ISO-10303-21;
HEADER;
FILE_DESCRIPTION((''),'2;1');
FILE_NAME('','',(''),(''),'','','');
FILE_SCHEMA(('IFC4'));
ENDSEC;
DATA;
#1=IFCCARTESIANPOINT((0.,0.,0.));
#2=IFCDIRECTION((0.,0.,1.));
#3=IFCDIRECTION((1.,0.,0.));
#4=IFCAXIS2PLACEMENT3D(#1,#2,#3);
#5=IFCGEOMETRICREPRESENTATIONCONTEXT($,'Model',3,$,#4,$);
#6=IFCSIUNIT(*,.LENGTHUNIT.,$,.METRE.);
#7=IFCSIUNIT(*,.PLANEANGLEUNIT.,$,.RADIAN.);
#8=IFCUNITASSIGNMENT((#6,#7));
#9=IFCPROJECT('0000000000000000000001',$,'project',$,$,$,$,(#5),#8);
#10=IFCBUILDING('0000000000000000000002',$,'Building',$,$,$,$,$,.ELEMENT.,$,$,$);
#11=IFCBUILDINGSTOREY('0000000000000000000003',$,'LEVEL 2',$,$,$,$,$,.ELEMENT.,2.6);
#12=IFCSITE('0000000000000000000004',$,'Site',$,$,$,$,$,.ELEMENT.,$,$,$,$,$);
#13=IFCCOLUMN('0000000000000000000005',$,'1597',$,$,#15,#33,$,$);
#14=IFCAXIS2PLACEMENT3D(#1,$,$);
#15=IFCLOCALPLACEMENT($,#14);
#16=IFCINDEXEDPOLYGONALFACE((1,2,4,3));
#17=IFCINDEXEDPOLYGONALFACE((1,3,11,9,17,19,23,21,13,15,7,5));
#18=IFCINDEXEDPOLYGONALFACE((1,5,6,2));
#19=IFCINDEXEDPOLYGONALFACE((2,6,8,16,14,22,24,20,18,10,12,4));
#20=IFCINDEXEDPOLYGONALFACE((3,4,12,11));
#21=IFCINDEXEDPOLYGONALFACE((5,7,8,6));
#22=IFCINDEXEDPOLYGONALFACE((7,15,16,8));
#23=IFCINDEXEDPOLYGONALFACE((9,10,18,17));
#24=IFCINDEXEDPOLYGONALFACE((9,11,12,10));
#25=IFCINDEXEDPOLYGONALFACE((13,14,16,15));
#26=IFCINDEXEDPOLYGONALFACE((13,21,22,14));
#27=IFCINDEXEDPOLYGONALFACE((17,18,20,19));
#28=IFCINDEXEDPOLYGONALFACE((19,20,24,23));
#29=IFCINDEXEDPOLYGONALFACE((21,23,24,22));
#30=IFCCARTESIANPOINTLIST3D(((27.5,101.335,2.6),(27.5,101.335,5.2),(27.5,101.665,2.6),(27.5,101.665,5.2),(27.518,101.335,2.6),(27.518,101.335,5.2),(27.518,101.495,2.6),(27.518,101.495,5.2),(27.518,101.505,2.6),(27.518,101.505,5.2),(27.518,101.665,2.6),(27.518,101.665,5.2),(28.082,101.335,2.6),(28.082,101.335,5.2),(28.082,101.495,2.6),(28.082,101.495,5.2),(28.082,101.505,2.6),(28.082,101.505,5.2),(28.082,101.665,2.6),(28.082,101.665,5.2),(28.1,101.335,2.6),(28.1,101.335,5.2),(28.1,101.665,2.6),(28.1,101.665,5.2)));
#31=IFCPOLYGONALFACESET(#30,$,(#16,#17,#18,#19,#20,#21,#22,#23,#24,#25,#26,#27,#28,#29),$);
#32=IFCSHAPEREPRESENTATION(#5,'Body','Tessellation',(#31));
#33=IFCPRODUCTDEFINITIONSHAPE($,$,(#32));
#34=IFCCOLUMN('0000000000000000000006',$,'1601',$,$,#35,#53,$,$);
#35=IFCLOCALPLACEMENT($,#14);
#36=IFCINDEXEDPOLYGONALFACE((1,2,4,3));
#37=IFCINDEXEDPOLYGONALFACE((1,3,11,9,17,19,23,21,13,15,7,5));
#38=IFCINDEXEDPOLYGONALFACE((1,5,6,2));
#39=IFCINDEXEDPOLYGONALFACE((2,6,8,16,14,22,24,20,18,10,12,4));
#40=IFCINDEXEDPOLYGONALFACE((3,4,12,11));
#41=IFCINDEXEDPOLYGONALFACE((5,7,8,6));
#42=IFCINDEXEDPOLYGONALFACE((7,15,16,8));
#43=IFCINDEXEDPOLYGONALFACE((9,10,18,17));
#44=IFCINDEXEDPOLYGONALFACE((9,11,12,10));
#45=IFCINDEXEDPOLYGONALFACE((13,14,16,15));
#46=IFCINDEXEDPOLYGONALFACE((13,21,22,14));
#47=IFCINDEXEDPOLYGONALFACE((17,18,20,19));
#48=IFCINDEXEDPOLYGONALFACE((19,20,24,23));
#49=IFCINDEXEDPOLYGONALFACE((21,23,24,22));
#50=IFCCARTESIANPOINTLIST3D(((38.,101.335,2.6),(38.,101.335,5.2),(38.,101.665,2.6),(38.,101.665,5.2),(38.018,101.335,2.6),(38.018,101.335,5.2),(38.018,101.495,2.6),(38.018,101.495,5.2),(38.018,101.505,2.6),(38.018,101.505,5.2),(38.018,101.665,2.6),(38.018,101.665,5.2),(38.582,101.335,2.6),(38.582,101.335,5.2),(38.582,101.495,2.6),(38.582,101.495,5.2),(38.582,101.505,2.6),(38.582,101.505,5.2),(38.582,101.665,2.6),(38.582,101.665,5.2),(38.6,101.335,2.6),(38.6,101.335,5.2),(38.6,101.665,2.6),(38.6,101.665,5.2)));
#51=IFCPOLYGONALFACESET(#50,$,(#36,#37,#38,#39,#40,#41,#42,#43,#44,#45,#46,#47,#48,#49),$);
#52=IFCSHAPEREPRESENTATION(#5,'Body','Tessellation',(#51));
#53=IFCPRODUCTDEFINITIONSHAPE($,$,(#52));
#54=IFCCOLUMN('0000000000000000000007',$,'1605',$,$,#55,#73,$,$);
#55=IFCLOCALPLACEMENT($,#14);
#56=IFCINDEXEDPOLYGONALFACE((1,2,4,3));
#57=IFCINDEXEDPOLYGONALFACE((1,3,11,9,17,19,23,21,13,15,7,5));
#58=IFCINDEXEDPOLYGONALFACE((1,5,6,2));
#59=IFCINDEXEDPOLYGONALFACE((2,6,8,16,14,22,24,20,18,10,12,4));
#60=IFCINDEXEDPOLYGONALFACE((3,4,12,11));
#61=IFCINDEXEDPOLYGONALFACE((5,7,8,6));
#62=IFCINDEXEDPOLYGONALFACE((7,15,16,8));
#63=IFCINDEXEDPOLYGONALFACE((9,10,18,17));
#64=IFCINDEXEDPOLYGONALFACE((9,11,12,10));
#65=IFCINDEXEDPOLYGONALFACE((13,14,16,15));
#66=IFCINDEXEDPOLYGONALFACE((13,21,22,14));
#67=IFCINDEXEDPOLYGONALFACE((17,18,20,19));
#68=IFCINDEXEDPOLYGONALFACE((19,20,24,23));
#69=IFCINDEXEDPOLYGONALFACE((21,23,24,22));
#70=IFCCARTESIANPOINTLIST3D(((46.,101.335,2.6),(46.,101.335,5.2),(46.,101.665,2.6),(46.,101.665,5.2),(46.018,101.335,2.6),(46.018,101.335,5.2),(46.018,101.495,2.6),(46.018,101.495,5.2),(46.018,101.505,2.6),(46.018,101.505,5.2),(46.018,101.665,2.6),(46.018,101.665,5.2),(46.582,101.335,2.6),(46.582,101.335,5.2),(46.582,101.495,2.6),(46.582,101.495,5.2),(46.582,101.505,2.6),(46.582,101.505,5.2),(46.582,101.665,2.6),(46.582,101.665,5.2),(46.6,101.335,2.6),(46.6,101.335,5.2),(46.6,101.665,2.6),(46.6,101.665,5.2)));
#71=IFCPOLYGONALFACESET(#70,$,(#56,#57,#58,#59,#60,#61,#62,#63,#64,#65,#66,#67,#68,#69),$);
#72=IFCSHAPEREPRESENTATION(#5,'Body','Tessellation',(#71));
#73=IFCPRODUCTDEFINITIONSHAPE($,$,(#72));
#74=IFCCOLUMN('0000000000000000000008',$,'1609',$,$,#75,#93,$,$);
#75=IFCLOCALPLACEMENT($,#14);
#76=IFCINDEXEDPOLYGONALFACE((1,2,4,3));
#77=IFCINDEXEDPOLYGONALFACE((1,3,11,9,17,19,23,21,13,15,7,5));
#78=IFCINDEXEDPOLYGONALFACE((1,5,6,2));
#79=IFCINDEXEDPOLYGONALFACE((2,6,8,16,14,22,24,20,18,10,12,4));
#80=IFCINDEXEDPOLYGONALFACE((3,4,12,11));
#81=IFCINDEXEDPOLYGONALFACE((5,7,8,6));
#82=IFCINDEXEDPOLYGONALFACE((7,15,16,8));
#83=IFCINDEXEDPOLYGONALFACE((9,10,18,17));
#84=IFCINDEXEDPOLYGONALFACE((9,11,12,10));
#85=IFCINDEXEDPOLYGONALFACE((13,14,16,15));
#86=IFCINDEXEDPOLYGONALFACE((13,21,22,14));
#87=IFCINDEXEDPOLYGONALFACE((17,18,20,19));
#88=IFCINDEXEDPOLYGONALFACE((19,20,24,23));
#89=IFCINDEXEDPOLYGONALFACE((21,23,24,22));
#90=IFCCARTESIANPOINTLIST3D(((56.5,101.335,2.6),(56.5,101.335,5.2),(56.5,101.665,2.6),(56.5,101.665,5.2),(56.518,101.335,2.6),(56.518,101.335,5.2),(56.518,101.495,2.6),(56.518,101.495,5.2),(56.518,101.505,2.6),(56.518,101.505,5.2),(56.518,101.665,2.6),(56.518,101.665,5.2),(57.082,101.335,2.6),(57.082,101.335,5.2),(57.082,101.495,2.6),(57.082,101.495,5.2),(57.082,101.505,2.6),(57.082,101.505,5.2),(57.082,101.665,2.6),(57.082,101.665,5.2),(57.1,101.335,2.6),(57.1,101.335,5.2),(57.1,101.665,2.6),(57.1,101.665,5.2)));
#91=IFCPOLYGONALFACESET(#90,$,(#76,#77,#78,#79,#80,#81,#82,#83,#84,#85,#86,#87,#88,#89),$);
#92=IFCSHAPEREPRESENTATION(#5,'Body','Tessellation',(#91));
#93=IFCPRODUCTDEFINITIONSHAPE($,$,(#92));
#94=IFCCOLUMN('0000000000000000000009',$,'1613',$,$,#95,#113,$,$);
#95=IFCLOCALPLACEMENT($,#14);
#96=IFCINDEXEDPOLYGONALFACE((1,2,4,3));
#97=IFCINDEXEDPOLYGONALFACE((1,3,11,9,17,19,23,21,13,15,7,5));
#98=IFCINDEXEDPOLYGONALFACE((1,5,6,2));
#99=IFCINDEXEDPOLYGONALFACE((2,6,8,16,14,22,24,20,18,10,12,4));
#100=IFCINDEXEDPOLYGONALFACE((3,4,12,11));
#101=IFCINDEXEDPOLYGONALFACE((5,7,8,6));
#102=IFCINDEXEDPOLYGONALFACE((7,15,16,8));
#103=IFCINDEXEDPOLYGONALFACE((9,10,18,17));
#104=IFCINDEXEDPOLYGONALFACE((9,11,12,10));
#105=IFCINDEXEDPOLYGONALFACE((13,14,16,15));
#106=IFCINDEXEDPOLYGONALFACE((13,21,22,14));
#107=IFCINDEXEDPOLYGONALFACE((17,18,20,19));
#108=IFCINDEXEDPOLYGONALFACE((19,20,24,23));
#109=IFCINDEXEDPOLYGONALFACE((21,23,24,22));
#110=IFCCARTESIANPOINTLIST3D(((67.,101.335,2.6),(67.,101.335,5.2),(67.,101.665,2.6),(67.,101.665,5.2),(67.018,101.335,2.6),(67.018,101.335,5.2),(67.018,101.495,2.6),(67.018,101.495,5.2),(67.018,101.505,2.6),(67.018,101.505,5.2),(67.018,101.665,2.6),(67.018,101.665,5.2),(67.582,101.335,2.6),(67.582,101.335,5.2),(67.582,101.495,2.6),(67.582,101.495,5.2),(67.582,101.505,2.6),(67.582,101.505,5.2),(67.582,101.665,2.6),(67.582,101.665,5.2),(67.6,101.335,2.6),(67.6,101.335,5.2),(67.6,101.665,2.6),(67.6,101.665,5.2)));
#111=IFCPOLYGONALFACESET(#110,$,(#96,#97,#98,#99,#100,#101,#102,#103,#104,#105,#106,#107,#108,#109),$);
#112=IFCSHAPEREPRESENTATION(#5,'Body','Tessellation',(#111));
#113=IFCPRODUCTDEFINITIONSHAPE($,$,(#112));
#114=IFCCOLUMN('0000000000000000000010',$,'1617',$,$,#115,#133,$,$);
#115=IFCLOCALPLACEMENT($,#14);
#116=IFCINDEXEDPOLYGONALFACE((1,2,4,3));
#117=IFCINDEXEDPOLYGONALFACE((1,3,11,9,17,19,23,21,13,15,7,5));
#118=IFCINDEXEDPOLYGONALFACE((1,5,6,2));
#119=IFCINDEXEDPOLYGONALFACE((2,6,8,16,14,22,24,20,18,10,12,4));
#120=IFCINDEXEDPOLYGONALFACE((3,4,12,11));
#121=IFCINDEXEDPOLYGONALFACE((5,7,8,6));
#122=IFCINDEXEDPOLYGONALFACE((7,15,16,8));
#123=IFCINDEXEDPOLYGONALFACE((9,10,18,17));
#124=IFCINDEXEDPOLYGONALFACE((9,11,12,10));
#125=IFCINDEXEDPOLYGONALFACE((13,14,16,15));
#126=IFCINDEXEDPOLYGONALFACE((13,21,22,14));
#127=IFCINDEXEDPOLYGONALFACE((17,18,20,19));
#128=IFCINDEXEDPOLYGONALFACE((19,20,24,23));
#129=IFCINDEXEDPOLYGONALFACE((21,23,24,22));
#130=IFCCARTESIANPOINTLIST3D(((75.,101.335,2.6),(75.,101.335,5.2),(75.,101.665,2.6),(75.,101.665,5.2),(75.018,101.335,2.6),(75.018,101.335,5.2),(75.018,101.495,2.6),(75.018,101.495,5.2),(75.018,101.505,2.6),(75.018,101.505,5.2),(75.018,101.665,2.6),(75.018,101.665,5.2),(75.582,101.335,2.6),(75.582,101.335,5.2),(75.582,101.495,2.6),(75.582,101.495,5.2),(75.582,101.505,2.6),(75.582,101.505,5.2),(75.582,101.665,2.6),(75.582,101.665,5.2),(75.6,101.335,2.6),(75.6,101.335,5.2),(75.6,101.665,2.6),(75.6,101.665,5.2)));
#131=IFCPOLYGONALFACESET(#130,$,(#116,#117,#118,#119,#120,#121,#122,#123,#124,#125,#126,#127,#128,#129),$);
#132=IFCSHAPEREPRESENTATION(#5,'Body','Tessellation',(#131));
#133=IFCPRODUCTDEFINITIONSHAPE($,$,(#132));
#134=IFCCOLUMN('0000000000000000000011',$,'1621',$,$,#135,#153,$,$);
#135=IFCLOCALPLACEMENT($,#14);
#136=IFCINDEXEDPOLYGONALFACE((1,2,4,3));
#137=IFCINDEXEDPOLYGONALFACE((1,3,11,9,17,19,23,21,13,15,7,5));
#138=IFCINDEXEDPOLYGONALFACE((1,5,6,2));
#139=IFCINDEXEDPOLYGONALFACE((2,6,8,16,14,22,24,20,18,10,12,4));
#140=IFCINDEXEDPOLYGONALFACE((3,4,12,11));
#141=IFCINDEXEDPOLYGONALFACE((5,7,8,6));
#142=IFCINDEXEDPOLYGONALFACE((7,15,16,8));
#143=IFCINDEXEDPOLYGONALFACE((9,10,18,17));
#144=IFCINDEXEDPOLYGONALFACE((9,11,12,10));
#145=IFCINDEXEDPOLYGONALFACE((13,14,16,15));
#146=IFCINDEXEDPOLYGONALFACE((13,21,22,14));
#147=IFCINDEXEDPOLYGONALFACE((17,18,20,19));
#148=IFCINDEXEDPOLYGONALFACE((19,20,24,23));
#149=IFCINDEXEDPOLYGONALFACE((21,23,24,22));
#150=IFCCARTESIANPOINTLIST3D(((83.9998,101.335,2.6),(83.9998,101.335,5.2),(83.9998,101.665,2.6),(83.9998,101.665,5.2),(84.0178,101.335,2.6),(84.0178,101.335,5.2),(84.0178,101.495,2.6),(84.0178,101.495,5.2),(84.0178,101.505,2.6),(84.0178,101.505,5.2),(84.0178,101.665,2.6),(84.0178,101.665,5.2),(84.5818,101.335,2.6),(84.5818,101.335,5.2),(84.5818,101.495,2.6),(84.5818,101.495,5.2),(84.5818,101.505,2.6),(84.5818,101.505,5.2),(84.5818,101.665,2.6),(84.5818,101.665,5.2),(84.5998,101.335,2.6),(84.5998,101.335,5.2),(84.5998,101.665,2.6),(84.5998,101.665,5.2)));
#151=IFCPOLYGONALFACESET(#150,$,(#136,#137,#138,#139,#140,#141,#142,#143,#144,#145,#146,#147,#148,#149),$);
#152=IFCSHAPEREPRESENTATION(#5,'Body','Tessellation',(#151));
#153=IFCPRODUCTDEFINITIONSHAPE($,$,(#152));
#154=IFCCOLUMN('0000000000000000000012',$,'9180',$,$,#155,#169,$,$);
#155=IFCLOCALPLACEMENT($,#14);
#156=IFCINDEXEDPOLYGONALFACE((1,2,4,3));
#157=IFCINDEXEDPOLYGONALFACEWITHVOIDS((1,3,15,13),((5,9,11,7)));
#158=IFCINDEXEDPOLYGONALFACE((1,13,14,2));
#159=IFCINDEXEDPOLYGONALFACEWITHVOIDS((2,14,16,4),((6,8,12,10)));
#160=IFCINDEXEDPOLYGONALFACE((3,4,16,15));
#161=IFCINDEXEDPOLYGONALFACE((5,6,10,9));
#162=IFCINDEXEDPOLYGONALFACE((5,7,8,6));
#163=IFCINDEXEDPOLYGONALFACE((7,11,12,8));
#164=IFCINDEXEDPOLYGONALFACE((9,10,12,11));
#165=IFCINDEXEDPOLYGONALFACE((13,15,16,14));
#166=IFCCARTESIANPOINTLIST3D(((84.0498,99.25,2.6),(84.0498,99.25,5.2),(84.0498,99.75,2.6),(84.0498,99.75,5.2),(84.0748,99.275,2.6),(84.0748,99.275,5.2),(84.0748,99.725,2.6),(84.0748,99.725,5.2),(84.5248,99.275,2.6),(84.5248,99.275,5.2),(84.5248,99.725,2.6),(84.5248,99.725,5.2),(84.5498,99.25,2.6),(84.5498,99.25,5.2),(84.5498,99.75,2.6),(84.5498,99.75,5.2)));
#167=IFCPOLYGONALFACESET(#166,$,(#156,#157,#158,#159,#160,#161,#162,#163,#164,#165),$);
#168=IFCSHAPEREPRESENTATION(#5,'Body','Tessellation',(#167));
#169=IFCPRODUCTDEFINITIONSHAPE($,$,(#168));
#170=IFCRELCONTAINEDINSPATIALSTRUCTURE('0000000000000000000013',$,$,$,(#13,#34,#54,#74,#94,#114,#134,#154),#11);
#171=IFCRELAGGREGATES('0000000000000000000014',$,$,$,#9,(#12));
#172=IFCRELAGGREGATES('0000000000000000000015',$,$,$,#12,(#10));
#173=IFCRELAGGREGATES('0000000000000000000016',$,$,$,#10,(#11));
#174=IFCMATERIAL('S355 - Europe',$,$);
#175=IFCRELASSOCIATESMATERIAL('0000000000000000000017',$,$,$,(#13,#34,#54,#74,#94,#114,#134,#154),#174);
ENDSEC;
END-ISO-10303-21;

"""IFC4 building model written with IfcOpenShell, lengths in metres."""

from ifc_helpers import new_model, si_unit, frame, origin_with_axes, origin_2d_with_axis, place, context, project, spatial, hollow_rectangle, i_section, extrude, material, material_profile, profile_set, profile_usage, element, save


model = new_model("IFC4")

# Units and contexts
model_context = context("Model", 3, world=origin_with_axes())
ifc_project = project(units=[si_unit("LENGTHUNIT", "METRE"), si_unit("PLANEANGLEUNIT", "RADIAN")], contexts=[model_context])

# Site, building, storey
site = spatial("IfcSite", under=ifc_project, Name="Site", CompositionType="ELEMENT")
building = spatial("IfcBuilding", under=site, Name="Building", CompositionType="ELEMENT")
storey = spatial("IfcBuildingStorey", under=building, Name="LEVEL 2", CompositionType="ELEMENT", Elevation=2.6)

# Columns
ifc_material = material(Name="S355 - Europe")
ifc_material_profile_1 = material_profile(ifc_material, i_section(OverallWidth=0.33, OverallDepth=0.6, WebThickness=0.01, FlangeThickness=0.018, at=origin_2d_with_axis()))
ifc_profile_set_1 = profile_set([ifc_material_profile_1])
ifc_profile_usage_1 = profile_usage(ifc_profile_set_1, cardinal=10)
column_1_placement = place(None, frame((27.8, 101.5, 2.6), z_axis=(0.0, 0.0, 1.0), x_axis=(0.0, -1.0, 0.0)))
element("IfcColumn", 1, at=column_1_placement, inside=storey, material=ifc_profile_usage_1, Name="1597", context=model_context, shape_type="SweptSolid", body=[
    extrude(i_section(OverallWidth=0.33, OverallDepth=0.6, WebThickness=0.01, FlangeThickness=0.018, at=origin_2d_with_axis()), origin_with_axes(), (0.0, 0.0, 1.0), 2.6),
])
ifc_material_profile_2 = material_profile(ifc_material, i_section(OverallWidth=0.33, OverallDepth=0.6, WebThickness=0.01, FlangeThickness=0.018, at=origin_2d_with_axis()))
ifc_profile_set_2 = profile_set([ifc_material_profile_2])
ifc_profile_usage_2 = profile_usage(ifc_profile_set_2, cardinal=10)
column_2_placement = place(None, frame((38.3, 101.5, 2.6), z_axis=(0.0, 0.0, 1.0), x_axis=(0.0, -1.0, 0.0)))
element("IfcColumn", 2, at=column_2_placement, inside=storey, material=ifc_profile_usage_2, Name="1601", context=model_context, shape_type="SweptSolid", body=[
    extrude(i_section(OverallWidth=0.33, OverallDepth=0.6, WebThickness=0.01, FlangeThickness=0.018, at=origin_2d_with_axis()), origin_with_axes(), (0.0, 0.0, 1.0), 2.6),
])
ifc_material_profile_3 = material_profile(ifc_material, i_section(OverallWidth=0.33, OverallDepth=0.6, WebThickness=0.01, FlangeThickness=0.018, at=origin_2d_with_axis()))
ifc_profile_set_3 = profile_set([ifc_material_profile_3])
ifc_profile_usage_3 = profile_usage(ifc_profile_set_3, cardinal=10)
column_3_placement = place(None, frame((46.3, 101.5, 2.6), z_axis=(0.0, 0.0, 1.0), x_axis=(0.0, -1.0, 0.0)))
element("IfcColumn", 3, at=column_3_placement, inside=storey, material=ifc_profile_usage_3, Name="1605", context=model_context, shape_type="SweptSolid", body=[
    extrude(i_section(OverallWidth=0.33, OverallDepth=0.6, WebThickness=0.01, FlangeThickness=0.018, at=origin_2d_with_axis()), origin_with_axes(), (0.0, 0.0, 1.0), 2.6),
])
ifc_material_profile_4 = material_profile(ifc_material, i_section(OverallWidth=0.33, OverallDepth=0.6, WebThickness=0.01, FlangeThickness=0.018, at=origin_2d_with_axis()))
ifc_profile_set_4 = profile_set([ifc_material_profile_4])
ifc_profile_usage_4 = profile_usage(ifc_profile_set_4, cardinal=10)
column_4_placement = place(None, frame((56.8, 101.5, 2.6), z_axis=(0.0, 0.0, 1.0), x_axis=(0.0, -1.0, 0.0)))
element("IfcColumn", 4, at=column_4_placement, inside=storey, material=ifc_profile_usage_4, Name="1609", context=model_context, shape_type="SweptSolid", body=[
    extrude(i_section(OverallWidth=0.33, OverallDepth=0.6, WebThickness=0.01, FlangeThickness=0.018, at=origin_2d_with_axis()), origin_with_axes(), (0.0, 0.0, 1.0), 2.6),
])
ifc_material_profile_5 = material_profile(ifc_material, i_section(OverallWidth=0.33, OverallDepth=0.6, WebThickness=0.01, FlangeThickness=0.018, at=origin_2d_with_axis()))
ifc_profile_set_5 = profile_set([ifc_material_profile_5])
ifc_profile_usage_5 = profile_usage(ifc_profile_set_5, cardinal=10)
column_5_placement = place(None, frame((67.3, 101.5, 2.6), z_axis=(0.0, 0.0, 1.0), x_axis=(0.0, -1.0, 0.0)))
element("IfcColumn", 5, at=column_5_placement, inside=storey, material=ifc_profile_usage_5, Name="1613", context=model_context, shape_type="SweptSolid", body=[
    extrude(i_section(OverallWidth=0.33, OverallDepth=0.6, WebThickness=0.01, FlangeThickness=0.018, at=origin_2d_with_axis()), origin_with_axes(), (0.0, 0.0, 1.0), 2.6),
])
ifc_material_profile_6 = material_profile(ifc_material, i_section(OverallWidth=0.33, OverallDepth=0.6, WebThickness=0.01, FlangeThickness=0.018, at=origin_2d_with_axis()))
ifc_profile_set_6 = profile_set([ifc_material_profile_6])
ifc_profile_usage_6 = profile_usage(ifc_profile_set_6, cardinal=10)
column_6_placement = place(None, frame((75.3, 101.5, 2.6), z_axis=(0.0, 0.0, 1.0), x_axis=(0.0, -1.0, 0.0)))
element("IfcColumn", 6, at=column_6_placement, inside=storey, material=ifc_profile_usage_6, Name="1617", context=model_context, shape_type="SweptSolid", body=[
    extrude(i_section(OverallWidth=0.33, OverallDepth=0.6, WebThickness=0.01, FlangeThickness=0.018, at=origin_2d_with_axis()), origin_with_axes(), (0.0, 0.0, 1.0), 2.6),
])
ifc_material_profile_7 = material_profile(ifc_material, i_section(OverallWidth=0.33, OverallDepth=0.6, WebThickness=0.01, FlangeThickness=0.018, at=origin_2d_with_axis()))
ifc_profile_set_7 = profile_set([ifc_material_profile_7])
ifc_profile_usage_7 = profile_usage(ifc_profile_set_7, cardinal=10)
column_7_placement = place(None, frame((84.2998, 101.5, 2.6), z_axis=(0.0, 0.0, 1.0), x_axis=(0.0, -1.0, 0.0)))
element("IfcColumn", 7, at=column_7_placement, inside=storey, material=ifc_profile_usage_7, Name="1621", context=model_context, shape_type="SweptSolid", body=[
    extrude(i_section(OverallWidth=0.33, OverallDepth=0.6, WebThickness=0.01, FlangeThickness=0.018, at=origin_2d_with_axis()), origin_with_axes(), (0.0, 0.0, 1.0), 2.6),
])
ifc_material_profile_8 = material_profile(ifc_material, hollow_rectangle(XDim=0.5, YDim=0.5, WallThickness=0.025, at=origin_2d_with_axis()))
ifc_profile_set_8 = profile_set([ifc_material_profile_8])
ifc_profile_usage_8 = profile_usage(ifc_profile_set_8, cardinal=10)
column_8_placement = place(None, frame((84.2998, 99.5, 2.6), z_axis=(0.0, 0.0, 1.0), x_axis=(0.0, -1.0, 0.0)))
element("IfcColumn", 8, at=column_8_placement, inside=storey, material=ifc_profile_usage_8, Name="9180", context=model_context, shape_type="SweptSolid", body=[
    extrude(hollow_rectangle(XDim=0.5, YDim=0.5, WallThickness=0.025, at=origin_2d_with_axis()), origin_with_axes(), (0.0, 0.0, 1.0), 2.6),
])

save(model, "model.ifc")
